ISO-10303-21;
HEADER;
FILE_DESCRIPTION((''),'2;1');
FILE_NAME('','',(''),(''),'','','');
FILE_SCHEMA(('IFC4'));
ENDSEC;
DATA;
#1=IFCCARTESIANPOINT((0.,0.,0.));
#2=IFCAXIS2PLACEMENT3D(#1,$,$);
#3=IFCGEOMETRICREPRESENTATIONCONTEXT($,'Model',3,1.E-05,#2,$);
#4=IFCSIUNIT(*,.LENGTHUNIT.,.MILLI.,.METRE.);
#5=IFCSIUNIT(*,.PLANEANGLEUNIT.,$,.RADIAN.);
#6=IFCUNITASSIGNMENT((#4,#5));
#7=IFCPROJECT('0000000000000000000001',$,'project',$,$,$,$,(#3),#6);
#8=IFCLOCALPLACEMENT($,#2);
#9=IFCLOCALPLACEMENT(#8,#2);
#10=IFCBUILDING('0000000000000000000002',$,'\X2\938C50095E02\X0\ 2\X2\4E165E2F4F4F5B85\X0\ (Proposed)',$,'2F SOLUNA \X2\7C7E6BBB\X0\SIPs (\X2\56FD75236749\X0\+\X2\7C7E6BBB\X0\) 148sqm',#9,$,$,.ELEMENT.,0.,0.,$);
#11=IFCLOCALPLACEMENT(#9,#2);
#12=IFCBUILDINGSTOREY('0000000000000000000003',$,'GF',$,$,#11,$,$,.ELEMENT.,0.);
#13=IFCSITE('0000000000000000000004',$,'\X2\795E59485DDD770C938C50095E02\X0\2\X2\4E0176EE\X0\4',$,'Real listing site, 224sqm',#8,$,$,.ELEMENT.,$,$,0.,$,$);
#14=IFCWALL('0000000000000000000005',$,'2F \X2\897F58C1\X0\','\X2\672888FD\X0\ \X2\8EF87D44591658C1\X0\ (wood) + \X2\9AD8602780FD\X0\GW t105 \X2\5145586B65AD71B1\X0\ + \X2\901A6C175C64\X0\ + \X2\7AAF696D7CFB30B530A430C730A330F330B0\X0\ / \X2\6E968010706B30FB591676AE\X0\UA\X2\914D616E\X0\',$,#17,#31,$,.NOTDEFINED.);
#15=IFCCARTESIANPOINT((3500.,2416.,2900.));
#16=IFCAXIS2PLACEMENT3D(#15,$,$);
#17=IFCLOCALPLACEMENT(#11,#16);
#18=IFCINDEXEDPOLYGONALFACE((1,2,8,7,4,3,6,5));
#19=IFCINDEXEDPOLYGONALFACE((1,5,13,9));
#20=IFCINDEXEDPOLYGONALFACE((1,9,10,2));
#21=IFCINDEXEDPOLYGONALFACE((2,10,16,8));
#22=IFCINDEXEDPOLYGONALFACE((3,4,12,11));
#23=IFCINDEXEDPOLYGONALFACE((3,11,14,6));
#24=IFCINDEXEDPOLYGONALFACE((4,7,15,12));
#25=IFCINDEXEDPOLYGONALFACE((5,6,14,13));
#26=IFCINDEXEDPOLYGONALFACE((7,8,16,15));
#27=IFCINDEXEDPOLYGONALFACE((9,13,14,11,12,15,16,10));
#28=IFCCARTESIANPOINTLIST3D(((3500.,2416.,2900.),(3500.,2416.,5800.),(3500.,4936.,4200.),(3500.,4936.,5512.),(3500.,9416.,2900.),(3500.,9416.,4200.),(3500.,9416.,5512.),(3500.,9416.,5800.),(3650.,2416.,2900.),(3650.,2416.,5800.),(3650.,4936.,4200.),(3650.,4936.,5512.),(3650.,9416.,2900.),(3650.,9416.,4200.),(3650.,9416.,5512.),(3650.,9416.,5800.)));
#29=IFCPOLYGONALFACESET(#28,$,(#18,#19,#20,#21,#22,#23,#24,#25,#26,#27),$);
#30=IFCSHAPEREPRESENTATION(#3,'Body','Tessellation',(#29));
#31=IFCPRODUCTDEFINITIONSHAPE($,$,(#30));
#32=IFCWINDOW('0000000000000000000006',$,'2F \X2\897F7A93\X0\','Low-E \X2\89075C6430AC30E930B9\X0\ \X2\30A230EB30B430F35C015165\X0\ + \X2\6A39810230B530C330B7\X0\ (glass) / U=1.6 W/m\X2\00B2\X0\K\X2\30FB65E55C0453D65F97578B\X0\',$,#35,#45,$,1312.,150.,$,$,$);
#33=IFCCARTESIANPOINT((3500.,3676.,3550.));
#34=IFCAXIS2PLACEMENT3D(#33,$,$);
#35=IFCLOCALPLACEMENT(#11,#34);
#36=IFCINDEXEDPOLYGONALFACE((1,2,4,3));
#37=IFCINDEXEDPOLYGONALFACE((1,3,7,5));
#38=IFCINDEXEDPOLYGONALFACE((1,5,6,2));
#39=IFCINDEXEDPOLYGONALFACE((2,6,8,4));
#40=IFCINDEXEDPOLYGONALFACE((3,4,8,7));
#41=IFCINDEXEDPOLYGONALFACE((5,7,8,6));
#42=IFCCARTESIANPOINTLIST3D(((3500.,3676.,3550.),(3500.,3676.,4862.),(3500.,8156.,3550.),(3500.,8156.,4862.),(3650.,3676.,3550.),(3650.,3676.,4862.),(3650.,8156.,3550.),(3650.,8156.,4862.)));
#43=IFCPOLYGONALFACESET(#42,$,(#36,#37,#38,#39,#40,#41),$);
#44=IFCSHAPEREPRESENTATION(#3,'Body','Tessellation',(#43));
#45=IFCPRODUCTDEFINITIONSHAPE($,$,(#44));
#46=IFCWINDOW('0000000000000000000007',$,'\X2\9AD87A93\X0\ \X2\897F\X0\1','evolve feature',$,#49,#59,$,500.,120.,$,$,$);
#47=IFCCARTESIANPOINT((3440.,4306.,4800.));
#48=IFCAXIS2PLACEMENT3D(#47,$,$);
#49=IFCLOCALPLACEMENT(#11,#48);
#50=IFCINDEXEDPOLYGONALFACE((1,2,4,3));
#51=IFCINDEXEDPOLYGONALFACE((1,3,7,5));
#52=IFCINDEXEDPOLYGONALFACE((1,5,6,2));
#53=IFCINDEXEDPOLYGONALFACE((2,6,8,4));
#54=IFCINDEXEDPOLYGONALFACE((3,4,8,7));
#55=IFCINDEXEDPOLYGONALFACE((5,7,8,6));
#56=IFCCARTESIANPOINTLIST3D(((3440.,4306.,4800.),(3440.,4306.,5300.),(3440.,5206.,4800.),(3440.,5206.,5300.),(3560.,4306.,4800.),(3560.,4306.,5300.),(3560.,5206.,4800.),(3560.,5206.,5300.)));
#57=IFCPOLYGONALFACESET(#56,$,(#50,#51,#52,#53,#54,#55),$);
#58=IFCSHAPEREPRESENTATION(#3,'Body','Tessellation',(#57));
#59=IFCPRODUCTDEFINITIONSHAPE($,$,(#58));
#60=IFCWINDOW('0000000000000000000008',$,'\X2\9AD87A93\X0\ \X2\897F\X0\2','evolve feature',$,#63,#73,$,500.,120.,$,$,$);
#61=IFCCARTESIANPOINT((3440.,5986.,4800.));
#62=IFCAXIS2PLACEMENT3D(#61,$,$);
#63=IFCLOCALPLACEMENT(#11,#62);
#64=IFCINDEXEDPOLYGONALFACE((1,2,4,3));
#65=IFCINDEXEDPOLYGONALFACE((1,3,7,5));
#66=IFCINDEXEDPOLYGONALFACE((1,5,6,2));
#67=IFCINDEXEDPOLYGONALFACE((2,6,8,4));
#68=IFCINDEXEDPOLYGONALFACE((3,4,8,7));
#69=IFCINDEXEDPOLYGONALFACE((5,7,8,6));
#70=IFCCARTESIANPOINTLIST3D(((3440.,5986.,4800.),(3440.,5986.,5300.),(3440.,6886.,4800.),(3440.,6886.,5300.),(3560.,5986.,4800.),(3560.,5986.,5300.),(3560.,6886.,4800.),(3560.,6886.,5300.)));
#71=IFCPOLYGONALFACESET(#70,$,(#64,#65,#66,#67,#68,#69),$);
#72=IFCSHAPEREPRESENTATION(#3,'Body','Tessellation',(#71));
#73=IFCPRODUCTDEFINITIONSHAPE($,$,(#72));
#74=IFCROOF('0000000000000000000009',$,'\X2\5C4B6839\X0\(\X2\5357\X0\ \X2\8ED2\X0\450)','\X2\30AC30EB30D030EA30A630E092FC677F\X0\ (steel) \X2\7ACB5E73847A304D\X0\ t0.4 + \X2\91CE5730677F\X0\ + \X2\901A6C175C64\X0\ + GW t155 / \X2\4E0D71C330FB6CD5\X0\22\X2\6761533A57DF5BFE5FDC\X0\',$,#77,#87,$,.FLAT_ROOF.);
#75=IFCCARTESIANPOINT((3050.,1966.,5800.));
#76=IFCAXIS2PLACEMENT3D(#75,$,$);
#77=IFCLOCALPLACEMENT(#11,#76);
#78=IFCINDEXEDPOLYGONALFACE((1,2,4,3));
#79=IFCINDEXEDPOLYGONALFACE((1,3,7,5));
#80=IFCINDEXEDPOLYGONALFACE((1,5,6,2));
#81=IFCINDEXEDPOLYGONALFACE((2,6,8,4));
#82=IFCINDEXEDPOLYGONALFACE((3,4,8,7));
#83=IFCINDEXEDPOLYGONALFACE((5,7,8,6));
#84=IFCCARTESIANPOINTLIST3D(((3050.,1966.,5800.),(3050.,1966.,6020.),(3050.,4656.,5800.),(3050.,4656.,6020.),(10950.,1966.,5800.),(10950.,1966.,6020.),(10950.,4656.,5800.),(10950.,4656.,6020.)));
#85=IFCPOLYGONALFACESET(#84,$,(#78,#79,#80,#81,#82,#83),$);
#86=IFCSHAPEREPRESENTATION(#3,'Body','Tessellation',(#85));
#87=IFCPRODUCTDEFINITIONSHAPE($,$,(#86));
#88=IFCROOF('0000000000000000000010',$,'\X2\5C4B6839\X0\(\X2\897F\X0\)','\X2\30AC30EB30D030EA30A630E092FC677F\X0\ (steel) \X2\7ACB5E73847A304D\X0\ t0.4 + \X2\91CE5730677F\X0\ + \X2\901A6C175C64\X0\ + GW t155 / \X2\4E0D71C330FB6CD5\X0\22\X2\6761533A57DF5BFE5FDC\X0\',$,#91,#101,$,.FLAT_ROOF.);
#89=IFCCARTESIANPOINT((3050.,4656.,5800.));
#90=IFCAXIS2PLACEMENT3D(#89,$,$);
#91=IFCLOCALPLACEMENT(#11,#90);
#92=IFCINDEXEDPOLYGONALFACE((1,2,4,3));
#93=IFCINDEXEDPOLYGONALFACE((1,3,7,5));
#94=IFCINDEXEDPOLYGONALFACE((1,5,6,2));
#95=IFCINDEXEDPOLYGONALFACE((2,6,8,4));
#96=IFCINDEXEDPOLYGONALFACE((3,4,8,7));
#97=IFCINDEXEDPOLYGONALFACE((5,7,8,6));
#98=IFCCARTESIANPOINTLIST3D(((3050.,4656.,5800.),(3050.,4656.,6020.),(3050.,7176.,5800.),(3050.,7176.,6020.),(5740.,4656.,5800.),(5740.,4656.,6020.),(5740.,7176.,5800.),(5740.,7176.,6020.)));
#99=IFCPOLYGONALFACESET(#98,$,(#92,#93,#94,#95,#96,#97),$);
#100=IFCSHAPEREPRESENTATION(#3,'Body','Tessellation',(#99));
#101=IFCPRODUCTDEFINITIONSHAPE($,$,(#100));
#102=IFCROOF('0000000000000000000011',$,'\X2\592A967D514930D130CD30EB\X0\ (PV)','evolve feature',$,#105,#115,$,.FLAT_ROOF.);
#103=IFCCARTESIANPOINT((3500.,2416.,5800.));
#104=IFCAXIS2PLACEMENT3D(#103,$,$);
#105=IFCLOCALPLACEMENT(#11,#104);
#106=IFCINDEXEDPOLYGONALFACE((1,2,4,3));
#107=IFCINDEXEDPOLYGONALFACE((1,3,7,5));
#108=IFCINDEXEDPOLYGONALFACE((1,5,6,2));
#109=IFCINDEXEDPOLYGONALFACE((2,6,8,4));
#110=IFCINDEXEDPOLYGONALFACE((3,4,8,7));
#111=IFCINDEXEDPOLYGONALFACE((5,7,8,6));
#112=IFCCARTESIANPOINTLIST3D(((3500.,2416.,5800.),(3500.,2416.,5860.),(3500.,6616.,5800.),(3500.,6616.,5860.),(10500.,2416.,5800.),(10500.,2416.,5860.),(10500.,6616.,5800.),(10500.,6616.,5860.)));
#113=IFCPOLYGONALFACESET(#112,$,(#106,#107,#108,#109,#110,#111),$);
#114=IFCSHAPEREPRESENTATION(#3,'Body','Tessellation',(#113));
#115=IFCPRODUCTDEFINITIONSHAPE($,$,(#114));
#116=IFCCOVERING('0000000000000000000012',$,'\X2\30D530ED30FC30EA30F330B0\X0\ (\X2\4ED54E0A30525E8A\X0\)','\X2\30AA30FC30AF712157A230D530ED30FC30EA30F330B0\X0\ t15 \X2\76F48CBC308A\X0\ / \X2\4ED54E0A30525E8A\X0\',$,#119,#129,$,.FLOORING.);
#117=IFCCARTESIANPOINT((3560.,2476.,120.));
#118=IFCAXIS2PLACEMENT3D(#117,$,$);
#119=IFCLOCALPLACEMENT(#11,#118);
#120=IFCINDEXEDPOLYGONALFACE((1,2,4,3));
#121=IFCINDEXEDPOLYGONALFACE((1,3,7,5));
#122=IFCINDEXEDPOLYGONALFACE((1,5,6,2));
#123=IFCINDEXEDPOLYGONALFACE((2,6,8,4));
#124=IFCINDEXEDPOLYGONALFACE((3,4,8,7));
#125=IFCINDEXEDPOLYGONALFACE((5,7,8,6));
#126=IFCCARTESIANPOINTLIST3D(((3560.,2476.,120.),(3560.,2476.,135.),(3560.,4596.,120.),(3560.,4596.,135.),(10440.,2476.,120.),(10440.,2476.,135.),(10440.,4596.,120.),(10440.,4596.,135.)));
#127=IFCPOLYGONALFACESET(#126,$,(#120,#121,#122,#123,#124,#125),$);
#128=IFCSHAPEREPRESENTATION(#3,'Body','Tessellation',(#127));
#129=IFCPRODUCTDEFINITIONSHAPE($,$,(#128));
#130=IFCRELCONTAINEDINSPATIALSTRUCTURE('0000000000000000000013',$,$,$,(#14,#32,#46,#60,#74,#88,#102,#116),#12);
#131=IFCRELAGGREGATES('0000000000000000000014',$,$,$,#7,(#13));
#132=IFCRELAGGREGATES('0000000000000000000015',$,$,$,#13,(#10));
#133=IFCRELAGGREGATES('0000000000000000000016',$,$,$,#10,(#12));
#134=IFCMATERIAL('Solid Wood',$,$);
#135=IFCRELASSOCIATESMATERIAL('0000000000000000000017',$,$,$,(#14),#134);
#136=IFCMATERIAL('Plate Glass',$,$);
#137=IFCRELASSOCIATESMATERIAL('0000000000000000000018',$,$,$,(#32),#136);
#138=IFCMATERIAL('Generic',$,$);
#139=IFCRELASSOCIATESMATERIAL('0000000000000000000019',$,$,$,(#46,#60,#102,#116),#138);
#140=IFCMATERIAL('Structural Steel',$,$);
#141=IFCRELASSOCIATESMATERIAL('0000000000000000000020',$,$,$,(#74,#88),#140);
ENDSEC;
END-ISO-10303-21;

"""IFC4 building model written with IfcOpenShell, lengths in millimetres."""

from ifc_helpers import new_model, si_unit, frame, frame_2d, origin, place, context, project, spatial, rectangle, extrude, material, element, fill, save


model = new_model("IFC4")

# Units and contexts
model_context = context("Model", 3, precision=1e-05, world=origin())
ifc_project = project(units=[si_unit("LENGTHUNIT", "METRE", prefix="MILLI"), si_unit("PLANEANGLEUNIT", "RADIAN")], contexts=[model_context])

# Site, building, storey
site_placement = place(None, origin())
site = spatial("IfcSite", under=ifc_project, at=site_placement, Name="神奈川県鎌倉市2丁目4", ObjectType="Real listing site, 224sqm", CompositionType="ELEMENT", RefElevation=0.0)
building_placement = place(site_placement, origin())
building = spatial("IfcBuilding", under=site, at=building_placement, Name="鎌倉市 2世帯住宅 (Proposed)", ObjectType="2F SOLUNA 籾殻SIPs (国産杉+籾殻) 148sqm", CompositionType="ELEMENT", ElevationOfRefHeight=0.0, ElevationOfTerrain=0.0)
storey_placement = place(building_placement, origin())
storey = spatial("IfcBuildingStorey", under=building, at=storey_placement, Name="GF", CompositionType="ELEMENT", Elevation=0.0)

# Shared definitions
ifc_material_1 = material(Name="Solid Wood")
ifc_material_2 = material(Name="Generic")

# Shared definitions
ifc_material_3 = material(Name="Plate Glass")

# Wall, openings, windows
wall_1_placement = place(storey_placement, frame((3500.0, 2416.0, 2900.0)))
wall_1 = element("IfcWall", 1, at=wall_1_placement, inside=storey, material=ifc_material_1, Name="2F 西壁", Description="木製 軸組外壁 (wood) + 高性能GW t105 充填断熱 + 通気層 + 窯業系サイディング / 準耐火・外皮UA配慮", PredefinedType="NOTDEFINED", context=model_context, shape_type="SweptSolid", body=[
    extrude(rectangle(XDim=150.0, YDim=7000.0, at=frame_2d((75.0, 3500.0))), frame((3500.0, 2416.0, 2900.0)), (0.0, 0.0, 1.0), 2900.0),
])
opening_1_placement = place(storey_placement, frame((3500.0, 3676.0, 3550.0)))
opening_1 = element("IfcOpeningElement", 2, at=opening_1_placement, cuts=wall_1, PredefinedType="NOTDEFINED", context=model_context, shape_type="SweptSolid", body=[
    extrude(rectangle(XDim=150.0, YDim=4480.0, at=frame_2d((75.0, 2240.0))), frame((3500.0, 3676.0, 3550.0)), (0.0, 0.0, 1.0), 1312.0),
])
opening_2_placement = place(storey_placement, frame((3440.0, 4306.0, 4800.0)))
opening_2 = element("IfcOpeningElement", 3, at=opening_2_placement, cuts=wall_1, PredefinedType="NOTDEFINED", context=model_context, shape_type="SweptSolid", body=[
    extrude(rectangle(XDim=120.0, YDim=900.0, at=frame_2d((60.0, 450.0))), frame((3440.0, 4306.0, 4800.0)), (0.0, 0.0, 1.0), 500.0),
])
opening_3_placement = place(storey_placement, frame((3440.0, 5986.0, 4800.0)))
opening_3 = element("IfcOpeningElement", 4, at=opening_3_placement, cuts=wall_1, PredefinedType="NOTDEFINED", context=model_context, shape_type="SweptSolid", body=[
    extrude(rectangle(XDim=120.0, YDim=900.0, at=frame_2d((60.0, 450.0))), frame((3440.0, 5986.0, 4800.0)), (0.0, 0.0, 1.0), 500.0),
])
window_1_placement = place(storey_placement, frame((3500.0, 3676.0, 3550.0)))
window_1 = element("IfcWindow", 5, at=window_1_placement, inside=storey, material=ifc_material_3, Name="2F 西窓", Description="Low-E 複層ガラス アルゴン封入 + 樹脂サッシ (glass) / U=1.6 W/m²K・日射取得型", OverallHeight=1312.0, OverallWidth=150.0, context=model_context, shape_type="SweptSolid", body=[
    extrude(rectangle(XDim=150.0, YDim=4480.0, at=frame_2d((75.0, 2240.0))), frame((3500.0, 3676.0, 3550.0)), (0.0, 0.0, 1.0), 1312.0),
])
fill(opening_1, window_1)
window_2_placement = place(storey_placement, frame((3440.0, 4306.0, 4800.0)))
window_2 = element("IfcWindow", 6, at=window_2_placement, inside=storey, material=ifc_material_2, Name="高窓 西1", Description="evolve feature", OverallHeight=500.0, OverallWidth=120.0, context=model_context, shape_type="SweptSolid", body=[
    extrude(rectangle(XDim=120.0, YDim=900.0, at=frame_2d((60.0, 450.0))), frame((3440.0, 4306.0, 4800.0)), (0.0, 0.0, 1.0), 500.0),
])
fill(opening_2, window_2)
window_3_placement = place(storey_placement, frame((3440.0, 5986.0, 4800.0)))
window_3 = element("IfcWindow", 7, at=window_3_placement, inside=storey, material=ifc_material_2, Name="高窓 西2", Description="evolve feature", OverallHeight=500.0, OverallWidth=120.0, context=model_context, shape_type="SweptSolid", body=[
    extrude(rectangle(XDim=120.0, YDim=900.0, at=frame_2d((60.0, 450.0))), frame((3440.0, 5986.0, 4800.0)), (0.0, 0.0, 1.0), 500.0),
])
fill(opening_3, window_3)

# Roofs
ifc_material_4 = material(Name="Structural Steel")
roof_1_placement = place(storey_placement, frame((3050.0, 1966.0, 5800.0)))
element("IfcRoof", 8, at=roof_1_placement, inside=storey, material=ifc_material_4, Name="屋根(南 軒450)", Description="ガルバリウム鋼板 (steel) 立平葺き t0.4 + 野地板 + 通気層 + GW t155 / 不燃・法22条区域対応", PredefinedType="FLAT_ROOF", context=model_context, shape_type="SweptSolid", body=[
    extrude(rectangle(XDim=7900.0, YDim=2690.0, at=frame_2d((3950.0, 1345.0))), frame((3050.0, 1966.0, 5800.0)), (0.0, 0.0, 1.0), 220.0),
])
roof_2_placement = place(storey_placement, frame((3050.0, 4656.0, 5800.0)))
element("IfcRoof", 9, at=roof_2_placement, inside=storey, material=ifc_material_4, Name="屋根(西)", Description="ガルバリウム鋼板 (steel) 立平葺き t0.4 + 野地板 + 通気層 + GW t155 / 不燃・法22条区域対応", PredefinedType="FLAT_ROOF", context=model_context, shape_type="SweptSolid", body=[
    extrude(rectangle(XDim=2690.0, YDim=2520.0, at=frame_2d((1345.0, 1260.0))), frame((3050.0, 4656.0, 5800.0)), (0.0, 0.0, 1.0), 220.0),
])
roof_3_placement = place(storey_placement, frame((3500.0, 2416.0, 5800.0)))
element("IfcRoof", 10, at=roof_3_placement, inside=storey, material=ifc_material_2, Name="太陽光パネル (PV)", Description="evolve feature", PredefinedType="FLAT_ROOF", context=model_context, shape_type="SweptSolid", body=[
    extrude(rectangle(XDim=7000.0, YDim=4200.0, at=frame_2d((3500.0, 2100.0))), frame((3500.0, 2416.0, 5800.0)), (0.0, 0.0, 1.0), 60.0),
])

# Covering
covering_placement = place(storey_placement, frame((3560.0, 2476.0, 120.0)))
element("IfcCovering", 11, at=covering_placement, inside=storey, material=ifc_material_2, Name="フローリング (仕上げ床)", Description="オーク無垢フローリング t15 直貼り / 仕上げ床", PredefinedType="FLOORING", context=model_context, shape_type="SweptSolid", body=[
    extrude(rectangle(XDim=6880.0, YDim=2120.0, at=frame_2d((3440.0, 1060.0))), frame((3560.0, 2476.0, 120.0)), (0.0, 0.0, 1.0), 15.0),
])

save(model, "model.ifc")
